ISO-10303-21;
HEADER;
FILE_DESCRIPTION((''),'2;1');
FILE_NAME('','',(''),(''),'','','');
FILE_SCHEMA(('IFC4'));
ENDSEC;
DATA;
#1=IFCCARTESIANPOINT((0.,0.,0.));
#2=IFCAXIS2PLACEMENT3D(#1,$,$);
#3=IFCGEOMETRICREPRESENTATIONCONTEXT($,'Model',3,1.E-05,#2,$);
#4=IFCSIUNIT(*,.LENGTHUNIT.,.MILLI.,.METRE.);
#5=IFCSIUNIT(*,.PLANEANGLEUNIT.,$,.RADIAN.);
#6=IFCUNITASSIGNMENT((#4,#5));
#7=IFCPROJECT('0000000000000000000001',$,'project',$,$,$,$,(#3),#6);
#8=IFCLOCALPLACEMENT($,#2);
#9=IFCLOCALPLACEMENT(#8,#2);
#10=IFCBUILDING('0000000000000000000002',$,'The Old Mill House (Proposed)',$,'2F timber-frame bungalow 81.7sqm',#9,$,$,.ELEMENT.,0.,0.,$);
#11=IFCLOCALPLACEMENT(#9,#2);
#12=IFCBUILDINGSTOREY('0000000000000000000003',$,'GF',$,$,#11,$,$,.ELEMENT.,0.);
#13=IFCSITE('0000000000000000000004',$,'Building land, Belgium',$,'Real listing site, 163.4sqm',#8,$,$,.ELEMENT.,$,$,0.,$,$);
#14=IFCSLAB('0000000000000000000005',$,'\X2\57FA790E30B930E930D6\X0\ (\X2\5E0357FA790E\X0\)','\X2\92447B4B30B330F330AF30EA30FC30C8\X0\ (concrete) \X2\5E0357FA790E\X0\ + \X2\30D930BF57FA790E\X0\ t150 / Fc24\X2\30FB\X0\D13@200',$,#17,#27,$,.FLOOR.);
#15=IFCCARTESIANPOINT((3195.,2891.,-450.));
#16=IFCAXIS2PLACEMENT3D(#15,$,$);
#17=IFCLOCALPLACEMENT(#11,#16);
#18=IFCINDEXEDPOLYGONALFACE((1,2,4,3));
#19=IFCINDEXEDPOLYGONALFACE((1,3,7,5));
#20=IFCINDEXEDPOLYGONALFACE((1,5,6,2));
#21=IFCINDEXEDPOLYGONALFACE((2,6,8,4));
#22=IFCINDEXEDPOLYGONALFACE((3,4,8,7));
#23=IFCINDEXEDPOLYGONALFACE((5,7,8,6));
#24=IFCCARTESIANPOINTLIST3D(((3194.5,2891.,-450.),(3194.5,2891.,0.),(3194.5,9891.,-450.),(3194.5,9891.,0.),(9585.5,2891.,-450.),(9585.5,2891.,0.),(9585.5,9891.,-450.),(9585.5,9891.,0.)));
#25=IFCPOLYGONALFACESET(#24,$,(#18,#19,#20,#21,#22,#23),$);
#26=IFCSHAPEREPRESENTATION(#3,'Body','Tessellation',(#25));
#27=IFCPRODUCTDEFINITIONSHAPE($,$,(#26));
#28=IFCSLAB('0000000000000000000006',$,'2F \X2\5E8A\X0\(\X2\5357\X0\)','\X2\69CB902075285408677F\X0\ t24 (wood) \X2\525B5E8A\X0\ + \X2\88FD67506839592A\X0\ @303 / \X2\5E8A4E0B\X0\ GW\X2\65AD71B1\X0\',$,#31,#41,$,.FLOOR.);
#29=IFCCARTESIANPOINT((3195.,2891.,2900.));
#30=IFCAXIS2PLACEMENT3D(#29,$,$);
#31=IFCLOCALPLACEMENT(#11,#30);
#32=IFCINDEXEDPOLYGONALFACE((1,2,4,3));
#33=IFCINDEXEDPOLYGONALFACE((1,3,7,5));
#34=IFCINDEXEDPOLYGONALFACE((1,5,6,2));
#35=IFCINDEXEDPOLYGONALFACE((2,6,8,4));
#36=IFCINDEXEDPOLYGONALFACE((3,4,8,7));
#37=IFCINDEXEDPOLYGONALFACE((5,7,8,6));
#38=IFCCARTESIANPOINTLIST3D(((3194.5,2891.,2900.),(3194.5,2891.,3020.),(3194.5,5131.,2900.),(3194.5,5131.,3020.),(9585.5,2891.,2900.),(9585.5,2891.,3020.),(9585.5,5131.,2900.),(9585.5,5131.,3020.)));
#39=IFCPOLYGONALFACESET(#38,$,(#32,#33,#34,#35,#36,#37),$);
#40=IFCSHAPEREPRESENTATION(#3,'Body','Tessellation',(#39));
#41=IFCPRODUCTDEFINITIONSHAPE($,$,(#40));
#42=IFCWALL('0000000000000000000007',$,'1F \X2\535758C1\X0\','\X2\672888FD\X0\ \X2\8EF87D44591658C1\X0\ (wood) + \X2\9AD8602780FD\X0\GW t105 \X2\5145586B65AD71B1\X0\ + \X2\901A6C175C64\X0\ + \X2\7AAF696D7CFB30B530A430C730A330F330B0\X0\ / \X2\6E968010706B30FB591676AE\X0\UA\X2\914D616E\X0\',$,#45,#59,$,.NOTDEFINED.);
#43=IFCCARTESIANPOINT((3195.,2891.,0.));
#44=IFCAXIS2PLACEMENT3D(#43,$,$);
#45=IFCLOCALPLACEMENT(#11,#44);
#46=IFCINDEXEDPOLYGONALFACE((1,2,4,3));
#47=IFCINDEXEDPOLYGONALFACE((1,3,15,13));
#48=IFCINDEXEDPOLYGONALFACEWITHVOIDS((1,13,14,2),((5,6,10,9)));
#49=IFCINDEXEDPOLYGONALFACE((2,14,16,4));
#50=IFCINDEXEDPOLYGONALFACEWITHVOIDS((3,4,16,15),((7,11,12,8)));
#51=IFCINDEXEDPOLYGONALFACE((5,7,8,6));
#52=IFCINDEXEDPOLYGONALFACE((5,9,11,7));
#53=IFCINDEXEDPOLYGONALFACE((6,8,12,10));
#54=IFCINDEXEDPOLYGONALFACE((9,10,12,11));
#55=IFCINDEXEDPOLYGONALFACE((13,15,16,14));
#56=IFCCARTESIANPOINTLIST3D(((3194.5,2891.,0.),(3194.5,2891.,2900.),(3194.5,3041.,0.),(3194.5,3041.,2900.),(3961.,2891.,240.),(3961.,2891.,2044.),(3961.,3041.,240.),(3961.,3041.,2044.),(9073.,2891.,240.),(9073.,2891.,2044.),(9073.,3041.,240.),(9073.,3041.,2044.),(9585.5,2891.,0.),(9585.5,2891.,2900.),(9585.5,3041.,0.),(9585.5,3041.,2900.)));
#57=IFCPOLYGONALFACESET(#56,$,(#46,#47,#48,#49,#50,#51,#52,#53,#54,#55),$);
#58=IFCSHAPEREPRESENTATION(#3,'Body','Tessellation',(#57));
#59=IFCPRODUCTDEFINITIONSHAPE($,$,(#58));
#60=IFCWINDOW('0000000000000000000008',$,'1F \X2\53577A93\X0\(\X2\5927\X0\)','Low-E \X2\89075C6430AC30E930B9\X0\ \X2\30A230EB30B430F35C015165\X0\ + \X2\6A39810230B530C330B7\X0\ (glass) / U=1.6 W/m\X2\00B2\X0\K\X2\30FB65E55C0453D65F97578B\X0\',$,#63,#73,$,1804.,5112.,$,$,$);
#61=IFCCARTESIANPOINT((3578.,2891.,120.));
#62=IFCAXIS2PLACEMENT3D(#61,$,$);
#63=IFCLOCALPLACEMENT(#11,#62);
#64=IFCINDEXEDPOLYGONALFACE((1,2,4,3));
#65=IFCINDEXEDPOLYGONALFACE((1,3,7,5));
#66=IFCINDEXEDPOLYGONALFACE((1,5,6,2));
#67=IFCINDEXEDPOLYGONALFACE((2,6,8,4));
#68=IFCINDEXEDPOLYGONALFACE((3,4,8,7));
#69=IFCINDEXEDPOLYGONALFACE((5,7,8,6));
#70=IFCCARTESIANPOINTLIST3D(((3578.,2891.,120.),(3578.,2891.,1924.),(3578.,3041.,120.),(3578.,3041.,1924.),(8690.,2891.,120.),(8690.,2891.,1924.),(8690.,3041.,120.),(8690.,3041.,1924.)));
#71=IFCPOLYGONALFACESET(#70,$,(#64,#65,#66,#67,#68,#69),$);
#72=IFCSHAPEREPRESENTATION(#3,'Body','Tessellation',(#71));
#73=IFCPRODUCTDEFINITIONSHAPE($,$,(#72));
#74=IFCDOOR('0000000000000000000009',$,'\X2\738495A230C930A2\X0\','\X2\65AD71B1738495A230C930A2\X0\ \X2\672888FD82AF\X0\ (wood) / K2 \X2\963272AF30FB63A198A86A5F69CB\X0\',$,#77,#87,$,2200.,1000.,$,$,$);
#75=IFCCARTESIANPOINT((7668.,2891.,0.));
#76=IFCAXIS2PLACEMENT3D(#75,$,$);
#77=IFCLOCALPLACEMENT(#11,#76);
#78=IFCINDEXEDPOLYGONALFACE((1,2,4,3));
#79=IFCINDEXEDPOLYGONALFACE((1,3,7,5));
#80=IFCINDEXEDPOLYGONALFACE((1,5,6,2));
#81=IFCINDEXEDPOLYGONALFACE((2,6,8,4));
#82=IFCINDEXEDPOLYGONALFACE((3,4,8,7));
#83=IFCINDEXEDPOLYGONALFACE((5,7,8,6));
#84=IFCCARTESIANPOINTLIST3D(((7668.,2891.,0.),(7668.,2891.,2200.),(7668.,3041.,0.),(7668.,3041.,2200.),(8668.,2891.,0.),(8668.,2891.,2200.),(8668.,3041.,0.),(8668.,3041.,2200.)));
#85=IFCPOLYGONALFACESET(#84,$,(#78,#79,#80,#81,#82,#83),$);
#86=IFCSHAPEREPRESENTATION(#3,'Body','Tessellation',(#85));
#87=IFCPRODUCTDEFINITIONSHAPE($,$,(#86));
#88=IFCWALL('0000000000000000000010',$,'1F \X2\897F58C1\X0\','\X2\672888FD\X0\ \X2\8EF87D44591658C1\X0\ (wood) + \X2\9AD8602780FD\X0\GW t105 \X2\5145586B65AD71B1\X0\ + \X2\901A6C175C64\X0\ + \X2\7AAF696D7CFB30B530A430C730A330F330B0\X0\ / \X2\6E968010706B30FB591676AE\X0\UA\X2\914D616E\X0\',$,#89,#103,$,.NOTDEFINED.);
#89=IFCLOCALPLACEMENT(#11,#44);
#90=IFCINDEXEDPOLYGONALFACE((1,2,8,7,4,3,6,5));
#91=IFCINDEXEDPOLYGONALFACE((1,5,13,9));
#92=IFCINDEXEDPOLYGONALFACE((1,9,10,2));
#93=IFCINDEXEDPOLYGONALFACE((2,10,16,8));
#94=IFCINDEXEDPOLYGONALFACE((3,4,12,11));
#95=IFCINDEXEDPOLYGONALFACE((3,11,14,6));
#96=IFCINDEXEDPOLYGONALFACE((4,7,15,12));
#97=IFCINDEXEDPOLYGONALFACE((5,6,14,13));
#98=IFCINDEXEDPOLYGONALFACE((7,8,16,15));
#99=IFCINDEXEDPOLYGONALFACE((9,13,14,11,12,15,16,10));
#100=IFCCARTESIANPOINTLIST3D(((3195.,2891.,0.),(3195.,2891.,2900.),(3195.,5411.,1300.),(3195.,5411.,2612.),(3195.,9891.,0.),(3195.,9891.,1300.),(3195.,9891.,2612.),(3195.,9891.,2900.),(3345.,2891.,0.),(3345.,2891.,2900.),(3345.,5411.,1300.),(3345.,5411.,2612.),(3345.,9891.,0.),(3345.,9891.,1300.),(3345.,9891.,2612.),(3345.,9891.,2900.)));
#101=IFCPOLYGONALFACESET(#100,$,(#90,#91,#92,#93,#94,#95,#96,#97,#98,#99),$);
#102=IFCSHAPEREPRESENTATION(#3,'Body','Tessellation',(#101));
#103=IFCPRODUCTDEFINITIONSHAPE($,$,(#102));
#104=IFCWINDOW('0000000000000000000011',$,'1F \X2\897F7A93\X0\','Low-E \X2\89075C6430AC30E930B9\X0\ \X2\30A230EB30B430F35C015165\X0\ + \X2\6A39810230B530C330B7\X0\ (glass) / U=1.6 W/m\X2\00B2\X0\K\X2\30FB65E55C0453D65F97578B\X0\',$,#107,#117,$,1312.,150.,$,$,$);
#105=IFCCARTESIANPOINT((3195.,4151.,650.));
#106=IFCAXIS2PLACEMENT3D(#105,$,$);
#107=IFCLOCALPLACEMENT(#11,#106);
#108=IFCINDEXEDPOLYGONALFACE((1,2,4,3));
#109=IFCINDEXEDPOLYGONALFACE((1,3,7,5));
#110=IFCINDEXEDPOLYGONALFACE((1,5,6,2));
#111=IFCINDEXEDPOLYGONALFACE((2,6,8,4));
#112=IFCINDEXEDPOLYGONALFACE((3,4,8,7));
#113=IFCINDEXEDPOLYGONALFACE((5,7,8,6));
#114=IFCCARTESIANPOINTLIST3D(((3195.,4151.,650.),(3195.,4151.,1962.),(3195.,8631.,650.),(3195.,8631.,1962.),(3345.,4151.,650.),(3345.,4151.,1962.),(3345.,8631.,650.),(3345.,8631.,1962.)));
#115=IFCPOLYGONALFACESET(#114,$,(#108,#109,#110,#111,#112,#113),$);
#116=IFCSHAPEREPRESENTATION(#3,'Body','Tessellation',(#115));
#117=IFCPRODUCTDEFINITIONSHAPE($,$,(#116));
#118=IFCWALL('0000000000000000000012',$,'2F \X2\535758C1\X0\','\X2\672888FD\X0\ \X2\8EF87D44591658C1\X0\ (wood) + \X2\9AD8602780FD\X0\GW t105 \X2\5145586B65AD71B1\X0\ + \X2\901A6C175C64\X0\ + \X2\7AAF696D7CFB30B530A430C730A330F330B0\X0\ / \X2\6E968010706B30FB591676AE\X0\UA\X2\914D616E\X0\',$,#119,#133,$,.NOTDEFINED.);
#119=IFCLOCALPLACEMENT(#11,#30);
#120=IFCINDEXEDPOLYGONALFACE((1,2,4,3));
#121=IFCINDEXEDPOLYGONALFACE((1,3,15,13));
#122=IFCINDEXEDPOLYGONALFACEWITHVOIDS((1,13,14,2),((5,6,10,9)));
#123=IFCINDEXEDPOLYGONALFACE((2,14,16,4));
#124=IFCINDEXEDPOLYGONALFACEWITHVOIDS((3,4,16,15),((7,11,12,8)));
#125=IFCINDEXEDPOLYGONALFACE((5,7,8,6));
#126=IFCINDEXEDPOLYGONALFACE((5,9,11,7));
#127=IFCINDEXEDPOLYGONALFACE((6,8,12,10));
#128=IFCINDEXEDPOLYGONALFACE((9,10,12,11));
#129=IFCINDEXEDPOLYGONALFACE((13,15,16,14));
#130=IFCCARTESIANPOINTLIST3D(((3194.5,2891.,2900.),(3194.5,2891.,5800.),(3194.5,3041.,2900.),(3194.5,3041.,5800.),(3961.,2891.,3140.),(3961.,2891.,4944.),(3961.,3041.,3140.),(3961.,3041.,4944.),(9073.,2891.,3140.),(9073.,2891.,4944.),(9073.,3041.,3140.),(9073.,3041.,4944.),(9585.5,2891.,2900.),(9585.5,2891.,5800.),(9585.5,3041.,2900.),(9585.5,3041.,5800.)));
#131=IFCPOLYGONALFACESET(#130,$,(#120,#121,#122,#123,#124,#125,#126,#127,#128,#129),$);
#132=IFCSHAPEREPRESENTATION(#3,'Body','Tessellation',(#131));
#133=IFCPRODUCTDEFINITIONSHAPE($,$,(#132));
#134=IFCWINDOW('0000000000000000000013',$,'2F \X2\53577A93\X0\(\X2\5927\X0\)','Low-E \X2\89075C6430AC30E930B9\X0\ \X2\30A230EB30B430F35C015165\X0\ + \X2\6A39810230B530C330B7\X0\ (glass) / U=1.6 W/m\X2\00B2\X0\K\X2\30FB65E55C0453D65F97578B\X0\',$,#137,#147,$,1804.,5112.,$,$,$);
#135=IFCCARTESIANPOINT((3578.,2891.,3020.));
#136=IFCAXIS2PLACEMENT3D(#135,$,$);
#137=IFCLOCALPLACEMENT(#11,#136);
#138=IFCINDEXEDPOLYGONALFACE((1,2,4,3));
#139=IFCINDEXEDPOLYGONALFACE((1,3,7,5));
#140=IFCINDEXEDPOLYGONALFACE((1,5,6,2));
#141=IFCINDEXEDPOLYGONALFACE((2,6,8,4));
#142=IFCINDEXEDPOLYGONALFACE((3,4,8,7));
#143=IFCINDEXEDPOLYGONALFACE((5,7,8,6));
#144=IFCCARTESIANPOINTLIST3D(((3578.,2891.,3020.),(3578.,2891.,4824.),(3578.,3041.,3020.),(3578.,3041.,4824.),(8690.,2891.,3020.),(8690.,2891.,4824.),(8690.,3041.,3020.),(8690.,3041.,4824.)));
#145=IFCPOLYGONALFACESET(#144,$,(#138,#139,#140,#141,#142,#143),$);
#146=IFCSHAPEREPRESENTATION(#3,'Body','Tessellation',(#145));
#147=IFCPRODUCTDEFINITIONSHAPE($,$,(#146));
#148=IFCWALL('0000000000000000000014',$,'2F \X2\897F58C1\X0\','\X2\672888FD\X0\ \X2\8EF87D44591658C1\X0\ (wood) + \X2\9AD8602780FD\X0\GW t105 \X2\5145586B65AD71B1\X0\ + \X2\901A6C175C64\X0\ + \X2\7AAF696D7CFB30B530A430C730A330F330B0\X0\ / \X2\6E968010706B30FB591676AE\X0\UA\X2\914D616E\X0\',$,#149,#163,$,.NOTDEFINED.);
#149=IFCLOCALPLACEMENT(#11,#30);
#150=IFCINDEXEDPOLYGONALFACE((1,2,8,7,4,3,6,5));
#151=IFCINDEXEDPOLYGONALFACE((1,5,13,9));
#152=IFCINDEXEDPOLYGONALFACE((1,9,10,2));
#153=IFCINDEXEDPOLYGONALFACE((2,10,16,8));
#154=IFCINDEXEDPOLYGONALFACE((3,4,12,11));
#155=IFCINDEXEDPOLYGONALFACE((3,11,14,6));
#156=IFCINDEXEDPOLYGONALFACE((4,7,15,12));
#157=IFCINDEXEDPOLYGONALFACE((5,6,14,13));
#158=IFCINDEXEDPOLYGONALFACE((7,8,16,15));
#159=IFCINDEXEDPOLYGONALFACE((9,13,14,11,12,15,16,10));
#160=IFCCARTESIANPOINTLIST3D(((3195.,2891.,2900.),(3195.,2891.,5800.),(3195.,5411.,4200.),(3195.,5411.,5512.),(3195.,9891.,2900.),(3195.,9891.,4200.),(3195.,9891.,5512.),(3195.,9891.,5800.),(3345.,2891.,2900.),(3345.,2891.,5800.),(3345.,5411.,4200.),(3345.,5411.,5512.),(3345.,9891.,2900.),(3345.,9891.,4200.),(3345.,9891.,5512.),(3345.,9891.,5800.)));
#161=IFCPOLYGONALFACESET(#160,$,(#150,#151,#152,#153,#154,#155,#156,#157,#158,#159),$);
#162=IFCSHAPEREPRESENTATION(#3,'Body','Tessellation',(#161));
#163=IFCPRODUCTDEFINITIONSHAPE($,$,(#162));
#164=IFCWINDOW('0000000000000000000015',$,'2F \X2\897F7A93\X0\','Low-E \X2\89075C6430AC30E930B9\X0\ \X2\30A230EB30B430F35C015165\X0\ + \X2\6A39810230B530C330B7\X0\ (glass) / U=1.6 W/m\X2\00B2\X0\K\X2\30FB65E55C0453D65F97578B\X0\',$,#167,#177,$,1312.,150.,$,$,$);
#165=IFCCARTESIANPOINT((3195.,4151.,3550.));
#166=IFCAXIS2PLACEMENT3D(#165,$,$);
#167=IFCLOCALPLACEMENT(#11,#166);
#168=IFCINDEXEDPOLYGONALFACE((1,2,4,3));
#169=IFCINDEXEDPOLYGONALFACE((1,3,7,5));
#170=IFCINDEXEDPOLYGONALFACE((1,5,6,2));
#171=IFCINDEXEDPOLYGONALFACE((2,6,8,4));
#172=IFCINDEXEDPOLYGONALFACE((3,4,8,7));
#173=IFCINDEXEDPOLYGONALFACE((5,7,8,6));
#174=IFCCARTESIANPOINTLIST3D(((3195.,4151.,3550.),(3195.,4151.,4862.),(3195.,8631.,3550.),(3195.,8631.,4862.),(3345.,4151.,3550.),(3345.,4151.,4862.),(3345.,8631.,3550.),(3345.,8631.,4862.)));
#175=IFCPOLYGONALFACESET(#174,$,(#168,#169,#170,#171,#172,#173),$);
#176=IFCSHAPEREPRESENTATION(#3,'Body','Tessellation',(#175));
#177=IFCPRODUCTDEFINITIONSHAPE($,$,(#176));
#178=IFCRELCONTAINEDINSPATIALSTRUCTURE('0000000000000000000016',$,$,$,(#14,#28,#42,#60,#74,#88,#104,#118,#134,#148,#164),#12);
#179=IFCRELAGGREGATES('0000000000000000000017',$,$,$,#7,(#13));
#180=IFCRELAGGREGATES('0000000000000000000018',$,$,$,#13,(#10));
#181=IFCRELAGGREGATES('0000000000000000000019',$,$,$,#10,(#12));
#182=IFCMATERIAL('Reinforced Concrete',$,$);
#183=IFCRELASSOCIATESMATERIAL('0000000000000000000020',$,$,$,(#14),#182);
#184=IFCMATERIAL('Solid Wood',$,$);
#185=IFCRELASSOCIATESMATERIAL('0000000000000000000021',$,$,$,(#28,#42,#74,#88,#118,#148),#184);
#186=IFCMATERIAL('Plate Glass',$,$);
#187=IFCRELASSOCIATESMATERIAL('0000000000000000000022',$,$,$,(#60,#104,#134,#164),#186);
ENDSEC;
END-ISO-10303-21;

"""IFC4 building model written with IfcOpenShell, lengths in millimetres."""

from ifc_helpers import new_model, si_unit, frame, frame_2d, origin, place, context, project, spatial, rectangle, extrude, material, element, fill, save


model = new_model("IFC4")

# Units and contexts
model_context = context("Model", 3, precision=1e-05, world=origin())
ifc_project = project(units=[si_unit("LENGTHUNIT", "METRE", prefix="MILLI"), si_unit("PLANEANGLEUNIT", "RADIAN")], contexts=[model_context])

# Site, building, storey
site_placement = place(None, origin())
site = spatial("IfcSite", under=ifc_project, at=site_placement, Name="Building land, Belgium", ObjectType="Real listing site, 163.4sqm", CompositionType="ELEMENT", RefElevation=0.0)
building_placement = place(site_placement, origin())
building = spatial("IfcBuilding", under=site, at=building_placement, Name="The Old Mill House (Proposed)", ObjectType="2F timber-frame bungalow 81.7sqm", CompositionType="ELEMENT", ElevationOfRefHeight=0.0, ElevationOfTerrain=0.0)
storey_placement = place(building_placement, origin())
storey = spatial("IfcBuildingStorey", under=building, at=storey_placement, Name="GF", CompositionType="ELEMENT", Elevation=0.0)

# Slabs
ifc_material_1 = material(Name="Reinforced Concrete")
slab_1_placement = place(storey_placement, frame((3195.0, 2891.0, -450.0)))
element("IfcSlab", 1, at=slab_1_placement, inside=storey, material=ifc_material_1, Name="基礎スラブ (布基礎)", Description="鉄筋コンクリート (concrete) 布基礎 + ベタ基礎 t150 / Fc24・D13@200", PredefinedType="FLOOR", context=model_context, shape_type="SweptSolid", body=[
    extrude(rectangle(XDim=6391.0, YDim=7000.0, at=frame_2d((3195.0, 3500.0))), frame((3195.0, 2891.0, -450.0)), (0.0, 0.0, 1.0), 450.0),
])
ifc_material_2 = material(Name="Solid Wood")
slab_2_placement = place(storey_placement, frame((3195.0, 2891.0, 2900.0)))
element("IfcSlab", 2, at=slab_2_placement, inside=storey, material=ifc_material_2, Name="2F 床(南)", Description="構造用合板 t24 (wood) 剛床 + 製材根太 @303 / 床下 GW断熱", PredefinedType="FLOOR", context=model_context, shape_type="SweptSolid", body=[
    extrude(rectangle(XDim=6391.0, YDim=2240.0, at=frame_2d((3195.0, 1120.0))), frame((3195.0, 2891.0, 2900.0)), (0.0, 0.0, 1.0), 120.0),
])

# Wall, openings, window, door
wall_1_placement = place(storey_placement, frame((3195.0, 2891.0, 0.0)))
wall_1 = element("IfcWall", 3, at=wall_1_placement, inside=storey, material=ifc_material_2, Name="1F 南壁", Description="木製 軸組外壁 (wood) + 高性能GW t105 充填断熱 + 通気層 + 窯業系サイディング / 準耐火・外皮UA配慮", PredefinedType="NOTDEFINED", context=model_context, shape_type="SweptSolid", body=[
    extrude(rectangle(XDim=6391.0, YDim=150.0, at=frame_2d((3195.0, 75.0))), frame((3195.0, 2891.0, 0.0)), (0.0, 0.0, 1.0), 2900.0),
])
opening_1_placement = place(storey_placement, frame((3578.0, 2891.0, 120.0)))
opening_1 = element("IfcOpeningElement", 4, at=opening_1_placement, cuts=wall_1, PredefinedType="NOTDEFINED", context=model_context, shape_type="SweptSolid", body=[
    extrude(rectangle(XDim=5112.0, YDim=150.0, at=frame_2d((2556.0, 75.0))), frame((3578.0, 2891.0, 120.0)), (0.0, 0.0, 1.0), 1804.0),
])
opening_2_placement = place(storey_placement, frame((7668.0, 2891.0, 0.0)))
opening_2 = element("IfcOpeningElement", 5, at=opening_2_placement, cuts=wall_1, PredefinedType="NOTDEFINED", context=model_context, shape_type="SweptSolid", body=[
    extrude(rectangle(XDim=1000.0, YDim=150.0, at=frame_2d((500.0, 75.0))), frame((7668.0, 2891.0, 0.0)), (0.0, 0.0, 1.0), 2200.0),
])
ifc_material_3 = material(Name="Plate Glass")
window_1_placement = place(storey_placement, frame((3578.0, 2891.0, 120.0)))
window_1 = element("IfcWindow", 6, at=window_1_placement, inside=storey, material=ifc_material_3, Name="1F 南窓(大)", Description="Low-E 複層ガラス アルゴン封入 + 樹脂サッシ (glass) / U=1.6 W/m²K・日射取得型", OverallHeight=1804.0, OverallWidth=5112.0, context=model_context, shape_type="SweptSolid", body=[
    extrude(rectangle(XDim=5112.0, YDim=150.0, at=frame_2d((2556.0, 75.0))), frame((3578.0, 2891.0, 120.0)), (0.0, 0.0, 1.0), 1804.0),
])
fill(opening_1, window_1)
door_placement = place(storey_placement, frame((7668.0, 2891.0, 0.0)))
door = element("IfcDoor", 7, at=door_placement, inside=storey, material=ifc_material_2, Name="玄関ドア", Description="断熱玄関ドア 木製芯 (wood) / K2 防犯・採風機構", OverallHeight=2200.0, OverallWidth=1000.0, context=model_context, shape_type="SweptSolid", body=[
    extrude(rectangle(XDim=1000.0, YDim=150.0, at=frame_2d((500.0, 75.0))), frame((7668.0, 2891.0, 0.0)), (0.0, 0.0, 1.0), 2200.0),
])
fill(opening_2, door)

# Walls, openings, windows
wall_2_placement = place(storey_placement, frame((3195.0, 2891.0, 0.0)))
wall_2 = element("IfcWall", 8, at=wall_2_placement, inside=storey, material=ifc_material_2, Name="1F 西壁", Description="木製 軸組外壁 (wood) + 高性能GW t105 充填断熱 + 通気層 + 窯業系サイディング / 準耐火・外皮UA配慮", PredefinedType="NOTDEFINED", context=model_context, shape_type="SweptSolid", body=[
    extrude(rectangle(XDim=150.0, YDim=7000.0, at=frame_2d((75.0, 3500.0))), frame((3195.0, 2891.0, 0.0)), (0.0, 0.0, 1.0), 2900.0),
])
opening_3_placement = place(storey_placement, frame((3195.0, 4151.0, 650.0)))
opening_3 = element("IfcOpeningElement", 9, at=opening_3_placement, cuts=wall_2, PredefinedType="NOTDEFINED", context=model_context, shape_type="SweptSolid", body=[
    extrude(rectangle(XDim=150.0, YDim=4480.0, at=frame_2d((75.0, 2240.0))), frame((3195.0, 4151.0, 650.0)), (0.0, 0.0, 1.0), 1312.0),
])
window_2_placement = place(storey_placement, frame((3195.0, 4151.0, 650.0)))
window_2 = element("IfcWindow", 10, at=window_2_placement, inside=storey, material=ifc_material_3, Name="1F 西窓", Description="Low-E 複層ガラス アルゴン封入 + 樹脂サッシ (glass) / U=1.6 W/m²K・日射取得型", OverallHeight=1312.0, OverallWidth=150.0, context=model_context, shape_type="SweptSolid", body=[
    extrude(rectangle(XDim=150.0, YDim=4480.0, at=frame_2d((75.0, 2240.0))), frame((3195.0, 4151.0, 650.0)), (0.0, 0.0, 1.0), 1312.0),
])
fill(opening_3, window_2)
wall_3_placement = place(storey_placement, frame((3195.0, 2891.0, 2900.0)))
wall_3 = element("IfcWall", 11, at=wall_3_placement, inside=storey, material=ifc_material_2, Name="2F 南壁", Description="木製 軸組外壁 (wood) + 高性能GW t105 充填断熱 + 通気層 + 窯業系サイディング / 準耐火・外皮UA配慮", PredefinedType="NOTDEFINED", context=model_context, shape_type="SweptSolid", body=[
    extrude(rectangle(XDim=6391.0, YDim=150.0, at=frame_2d((3195.0, 75.0))), frame((3195.0, 2891.0, 2900.0)), (0.0, 0.0, 1.0), 2900.0),
])
opening_4_placement = place(storey_placement, frame((3578.0, 2891.0, 3020.0)))
opening_4 = element("IfcOpeningElement", 12, at=opening_4_placement, cuts=wall_3, PredefinedType="NOTDEFINED", context=model_context, shape_type="SweptSolid", body=[
    extrude(rectangle(XDim=5112.0, YDim=150.0, at=frame_2d((2556.0, 75.0))), frame((3578.0, 2891.0, 3020.0)), (0.0, 0.0, 1.0), 1804.0),
])
window_3_placement = place(storey_placement, frame((3578.0, 2891.0, 3020.0)))
window_3 = element("IfcWindow", 13, at=window_3_placement, inside=storey, material=ifc_material_3, Name="2F 南窓(大)", Description="Low-E 複層ガラス アルゴン封入 + 樹脂サッシ (glass) / U=1.6 W/m²K・日射取得型", OverallHeight=1804.0, OverallWidth=5112.0, context=model_context, shape_type="SweptSolid", body=[
    extrude(rectangle(XDim=5112.0, YDim=150.0, at=frame_2d((2556.0, 75.0))), frame((3578.0, 2891.0, 3020.0)), (0.0, 0.0, 1.0), 1804.0),
])
fill(opening_4, window_3)
wall_4_placement = place(storey_placement, frame((3195.0, 2891.0, 2900.0)))
wall_4 = element("IfcWall", 14, at=wall_4_placement, inside=storey, material=ifc_material_2, Name="2F 西壁", Description="木製 軸組外壁 (wood) + 高性能GW t105 充填断熱 + 通気層 + 窯業系サイディング / 準耐火・外皮UA配慮", PredefinedType="NOTDEFINED", context=model_context, shape_type="SweptSolid", body=[
    extrude(rectangle(XDim=150.0, YDim=7000.0, at=frame_2d((75.0, 3500.0))), frame((3195.0, 2891.0, 2900.0)), (0.0, 0.0, 1.0), 2900.0),
])
opening_5_placement = place(storey_placement, frame((3195.0, 4151.0, 3550.0)))
opening_5 = element("IfcOpeningElement", 15, at=opening_5_placement, cuts=wall_4, PredefinedType="NOTDEFINED", context=model_context, shape_type="SweptSolid", body=[
    extrude(rectangle(XDim=150.0, YDim=4480.0, at=frame_2d((75.0, 2240.0))), frame((3195.0, 4151.0, 3550.0)), (0.0, 0.0, 1.0), 1312.0),
])
window_4_placement = place(storey_placement, frame((3195.0, 4151.0, 3550.0)))
window_4 = element("IfcWindow", 16, at=window_4_placement, inside=storey, material=ifc_material_3, Name="2F 西窓", Description="Low-E 複層ガラス アルゴン封入 + 樹脂サッシ (glass) / U=1.6 W/m²K・日射取得型", OverallHeight=1312.0, OverallWidth=150.0, context=model_context, shape_type="SweptSolid", body=[
    extrude(rectangle(XDim=150.0, YDim=4480.0, at=frame_2d((75.0, 2240.0))), frame((3195.0, 4151.0, 3550.0)), (0.0, 0.0, 1.0), 1312.0),
])
fill(opening_5, window_4)

save(model, "model.ifc")
